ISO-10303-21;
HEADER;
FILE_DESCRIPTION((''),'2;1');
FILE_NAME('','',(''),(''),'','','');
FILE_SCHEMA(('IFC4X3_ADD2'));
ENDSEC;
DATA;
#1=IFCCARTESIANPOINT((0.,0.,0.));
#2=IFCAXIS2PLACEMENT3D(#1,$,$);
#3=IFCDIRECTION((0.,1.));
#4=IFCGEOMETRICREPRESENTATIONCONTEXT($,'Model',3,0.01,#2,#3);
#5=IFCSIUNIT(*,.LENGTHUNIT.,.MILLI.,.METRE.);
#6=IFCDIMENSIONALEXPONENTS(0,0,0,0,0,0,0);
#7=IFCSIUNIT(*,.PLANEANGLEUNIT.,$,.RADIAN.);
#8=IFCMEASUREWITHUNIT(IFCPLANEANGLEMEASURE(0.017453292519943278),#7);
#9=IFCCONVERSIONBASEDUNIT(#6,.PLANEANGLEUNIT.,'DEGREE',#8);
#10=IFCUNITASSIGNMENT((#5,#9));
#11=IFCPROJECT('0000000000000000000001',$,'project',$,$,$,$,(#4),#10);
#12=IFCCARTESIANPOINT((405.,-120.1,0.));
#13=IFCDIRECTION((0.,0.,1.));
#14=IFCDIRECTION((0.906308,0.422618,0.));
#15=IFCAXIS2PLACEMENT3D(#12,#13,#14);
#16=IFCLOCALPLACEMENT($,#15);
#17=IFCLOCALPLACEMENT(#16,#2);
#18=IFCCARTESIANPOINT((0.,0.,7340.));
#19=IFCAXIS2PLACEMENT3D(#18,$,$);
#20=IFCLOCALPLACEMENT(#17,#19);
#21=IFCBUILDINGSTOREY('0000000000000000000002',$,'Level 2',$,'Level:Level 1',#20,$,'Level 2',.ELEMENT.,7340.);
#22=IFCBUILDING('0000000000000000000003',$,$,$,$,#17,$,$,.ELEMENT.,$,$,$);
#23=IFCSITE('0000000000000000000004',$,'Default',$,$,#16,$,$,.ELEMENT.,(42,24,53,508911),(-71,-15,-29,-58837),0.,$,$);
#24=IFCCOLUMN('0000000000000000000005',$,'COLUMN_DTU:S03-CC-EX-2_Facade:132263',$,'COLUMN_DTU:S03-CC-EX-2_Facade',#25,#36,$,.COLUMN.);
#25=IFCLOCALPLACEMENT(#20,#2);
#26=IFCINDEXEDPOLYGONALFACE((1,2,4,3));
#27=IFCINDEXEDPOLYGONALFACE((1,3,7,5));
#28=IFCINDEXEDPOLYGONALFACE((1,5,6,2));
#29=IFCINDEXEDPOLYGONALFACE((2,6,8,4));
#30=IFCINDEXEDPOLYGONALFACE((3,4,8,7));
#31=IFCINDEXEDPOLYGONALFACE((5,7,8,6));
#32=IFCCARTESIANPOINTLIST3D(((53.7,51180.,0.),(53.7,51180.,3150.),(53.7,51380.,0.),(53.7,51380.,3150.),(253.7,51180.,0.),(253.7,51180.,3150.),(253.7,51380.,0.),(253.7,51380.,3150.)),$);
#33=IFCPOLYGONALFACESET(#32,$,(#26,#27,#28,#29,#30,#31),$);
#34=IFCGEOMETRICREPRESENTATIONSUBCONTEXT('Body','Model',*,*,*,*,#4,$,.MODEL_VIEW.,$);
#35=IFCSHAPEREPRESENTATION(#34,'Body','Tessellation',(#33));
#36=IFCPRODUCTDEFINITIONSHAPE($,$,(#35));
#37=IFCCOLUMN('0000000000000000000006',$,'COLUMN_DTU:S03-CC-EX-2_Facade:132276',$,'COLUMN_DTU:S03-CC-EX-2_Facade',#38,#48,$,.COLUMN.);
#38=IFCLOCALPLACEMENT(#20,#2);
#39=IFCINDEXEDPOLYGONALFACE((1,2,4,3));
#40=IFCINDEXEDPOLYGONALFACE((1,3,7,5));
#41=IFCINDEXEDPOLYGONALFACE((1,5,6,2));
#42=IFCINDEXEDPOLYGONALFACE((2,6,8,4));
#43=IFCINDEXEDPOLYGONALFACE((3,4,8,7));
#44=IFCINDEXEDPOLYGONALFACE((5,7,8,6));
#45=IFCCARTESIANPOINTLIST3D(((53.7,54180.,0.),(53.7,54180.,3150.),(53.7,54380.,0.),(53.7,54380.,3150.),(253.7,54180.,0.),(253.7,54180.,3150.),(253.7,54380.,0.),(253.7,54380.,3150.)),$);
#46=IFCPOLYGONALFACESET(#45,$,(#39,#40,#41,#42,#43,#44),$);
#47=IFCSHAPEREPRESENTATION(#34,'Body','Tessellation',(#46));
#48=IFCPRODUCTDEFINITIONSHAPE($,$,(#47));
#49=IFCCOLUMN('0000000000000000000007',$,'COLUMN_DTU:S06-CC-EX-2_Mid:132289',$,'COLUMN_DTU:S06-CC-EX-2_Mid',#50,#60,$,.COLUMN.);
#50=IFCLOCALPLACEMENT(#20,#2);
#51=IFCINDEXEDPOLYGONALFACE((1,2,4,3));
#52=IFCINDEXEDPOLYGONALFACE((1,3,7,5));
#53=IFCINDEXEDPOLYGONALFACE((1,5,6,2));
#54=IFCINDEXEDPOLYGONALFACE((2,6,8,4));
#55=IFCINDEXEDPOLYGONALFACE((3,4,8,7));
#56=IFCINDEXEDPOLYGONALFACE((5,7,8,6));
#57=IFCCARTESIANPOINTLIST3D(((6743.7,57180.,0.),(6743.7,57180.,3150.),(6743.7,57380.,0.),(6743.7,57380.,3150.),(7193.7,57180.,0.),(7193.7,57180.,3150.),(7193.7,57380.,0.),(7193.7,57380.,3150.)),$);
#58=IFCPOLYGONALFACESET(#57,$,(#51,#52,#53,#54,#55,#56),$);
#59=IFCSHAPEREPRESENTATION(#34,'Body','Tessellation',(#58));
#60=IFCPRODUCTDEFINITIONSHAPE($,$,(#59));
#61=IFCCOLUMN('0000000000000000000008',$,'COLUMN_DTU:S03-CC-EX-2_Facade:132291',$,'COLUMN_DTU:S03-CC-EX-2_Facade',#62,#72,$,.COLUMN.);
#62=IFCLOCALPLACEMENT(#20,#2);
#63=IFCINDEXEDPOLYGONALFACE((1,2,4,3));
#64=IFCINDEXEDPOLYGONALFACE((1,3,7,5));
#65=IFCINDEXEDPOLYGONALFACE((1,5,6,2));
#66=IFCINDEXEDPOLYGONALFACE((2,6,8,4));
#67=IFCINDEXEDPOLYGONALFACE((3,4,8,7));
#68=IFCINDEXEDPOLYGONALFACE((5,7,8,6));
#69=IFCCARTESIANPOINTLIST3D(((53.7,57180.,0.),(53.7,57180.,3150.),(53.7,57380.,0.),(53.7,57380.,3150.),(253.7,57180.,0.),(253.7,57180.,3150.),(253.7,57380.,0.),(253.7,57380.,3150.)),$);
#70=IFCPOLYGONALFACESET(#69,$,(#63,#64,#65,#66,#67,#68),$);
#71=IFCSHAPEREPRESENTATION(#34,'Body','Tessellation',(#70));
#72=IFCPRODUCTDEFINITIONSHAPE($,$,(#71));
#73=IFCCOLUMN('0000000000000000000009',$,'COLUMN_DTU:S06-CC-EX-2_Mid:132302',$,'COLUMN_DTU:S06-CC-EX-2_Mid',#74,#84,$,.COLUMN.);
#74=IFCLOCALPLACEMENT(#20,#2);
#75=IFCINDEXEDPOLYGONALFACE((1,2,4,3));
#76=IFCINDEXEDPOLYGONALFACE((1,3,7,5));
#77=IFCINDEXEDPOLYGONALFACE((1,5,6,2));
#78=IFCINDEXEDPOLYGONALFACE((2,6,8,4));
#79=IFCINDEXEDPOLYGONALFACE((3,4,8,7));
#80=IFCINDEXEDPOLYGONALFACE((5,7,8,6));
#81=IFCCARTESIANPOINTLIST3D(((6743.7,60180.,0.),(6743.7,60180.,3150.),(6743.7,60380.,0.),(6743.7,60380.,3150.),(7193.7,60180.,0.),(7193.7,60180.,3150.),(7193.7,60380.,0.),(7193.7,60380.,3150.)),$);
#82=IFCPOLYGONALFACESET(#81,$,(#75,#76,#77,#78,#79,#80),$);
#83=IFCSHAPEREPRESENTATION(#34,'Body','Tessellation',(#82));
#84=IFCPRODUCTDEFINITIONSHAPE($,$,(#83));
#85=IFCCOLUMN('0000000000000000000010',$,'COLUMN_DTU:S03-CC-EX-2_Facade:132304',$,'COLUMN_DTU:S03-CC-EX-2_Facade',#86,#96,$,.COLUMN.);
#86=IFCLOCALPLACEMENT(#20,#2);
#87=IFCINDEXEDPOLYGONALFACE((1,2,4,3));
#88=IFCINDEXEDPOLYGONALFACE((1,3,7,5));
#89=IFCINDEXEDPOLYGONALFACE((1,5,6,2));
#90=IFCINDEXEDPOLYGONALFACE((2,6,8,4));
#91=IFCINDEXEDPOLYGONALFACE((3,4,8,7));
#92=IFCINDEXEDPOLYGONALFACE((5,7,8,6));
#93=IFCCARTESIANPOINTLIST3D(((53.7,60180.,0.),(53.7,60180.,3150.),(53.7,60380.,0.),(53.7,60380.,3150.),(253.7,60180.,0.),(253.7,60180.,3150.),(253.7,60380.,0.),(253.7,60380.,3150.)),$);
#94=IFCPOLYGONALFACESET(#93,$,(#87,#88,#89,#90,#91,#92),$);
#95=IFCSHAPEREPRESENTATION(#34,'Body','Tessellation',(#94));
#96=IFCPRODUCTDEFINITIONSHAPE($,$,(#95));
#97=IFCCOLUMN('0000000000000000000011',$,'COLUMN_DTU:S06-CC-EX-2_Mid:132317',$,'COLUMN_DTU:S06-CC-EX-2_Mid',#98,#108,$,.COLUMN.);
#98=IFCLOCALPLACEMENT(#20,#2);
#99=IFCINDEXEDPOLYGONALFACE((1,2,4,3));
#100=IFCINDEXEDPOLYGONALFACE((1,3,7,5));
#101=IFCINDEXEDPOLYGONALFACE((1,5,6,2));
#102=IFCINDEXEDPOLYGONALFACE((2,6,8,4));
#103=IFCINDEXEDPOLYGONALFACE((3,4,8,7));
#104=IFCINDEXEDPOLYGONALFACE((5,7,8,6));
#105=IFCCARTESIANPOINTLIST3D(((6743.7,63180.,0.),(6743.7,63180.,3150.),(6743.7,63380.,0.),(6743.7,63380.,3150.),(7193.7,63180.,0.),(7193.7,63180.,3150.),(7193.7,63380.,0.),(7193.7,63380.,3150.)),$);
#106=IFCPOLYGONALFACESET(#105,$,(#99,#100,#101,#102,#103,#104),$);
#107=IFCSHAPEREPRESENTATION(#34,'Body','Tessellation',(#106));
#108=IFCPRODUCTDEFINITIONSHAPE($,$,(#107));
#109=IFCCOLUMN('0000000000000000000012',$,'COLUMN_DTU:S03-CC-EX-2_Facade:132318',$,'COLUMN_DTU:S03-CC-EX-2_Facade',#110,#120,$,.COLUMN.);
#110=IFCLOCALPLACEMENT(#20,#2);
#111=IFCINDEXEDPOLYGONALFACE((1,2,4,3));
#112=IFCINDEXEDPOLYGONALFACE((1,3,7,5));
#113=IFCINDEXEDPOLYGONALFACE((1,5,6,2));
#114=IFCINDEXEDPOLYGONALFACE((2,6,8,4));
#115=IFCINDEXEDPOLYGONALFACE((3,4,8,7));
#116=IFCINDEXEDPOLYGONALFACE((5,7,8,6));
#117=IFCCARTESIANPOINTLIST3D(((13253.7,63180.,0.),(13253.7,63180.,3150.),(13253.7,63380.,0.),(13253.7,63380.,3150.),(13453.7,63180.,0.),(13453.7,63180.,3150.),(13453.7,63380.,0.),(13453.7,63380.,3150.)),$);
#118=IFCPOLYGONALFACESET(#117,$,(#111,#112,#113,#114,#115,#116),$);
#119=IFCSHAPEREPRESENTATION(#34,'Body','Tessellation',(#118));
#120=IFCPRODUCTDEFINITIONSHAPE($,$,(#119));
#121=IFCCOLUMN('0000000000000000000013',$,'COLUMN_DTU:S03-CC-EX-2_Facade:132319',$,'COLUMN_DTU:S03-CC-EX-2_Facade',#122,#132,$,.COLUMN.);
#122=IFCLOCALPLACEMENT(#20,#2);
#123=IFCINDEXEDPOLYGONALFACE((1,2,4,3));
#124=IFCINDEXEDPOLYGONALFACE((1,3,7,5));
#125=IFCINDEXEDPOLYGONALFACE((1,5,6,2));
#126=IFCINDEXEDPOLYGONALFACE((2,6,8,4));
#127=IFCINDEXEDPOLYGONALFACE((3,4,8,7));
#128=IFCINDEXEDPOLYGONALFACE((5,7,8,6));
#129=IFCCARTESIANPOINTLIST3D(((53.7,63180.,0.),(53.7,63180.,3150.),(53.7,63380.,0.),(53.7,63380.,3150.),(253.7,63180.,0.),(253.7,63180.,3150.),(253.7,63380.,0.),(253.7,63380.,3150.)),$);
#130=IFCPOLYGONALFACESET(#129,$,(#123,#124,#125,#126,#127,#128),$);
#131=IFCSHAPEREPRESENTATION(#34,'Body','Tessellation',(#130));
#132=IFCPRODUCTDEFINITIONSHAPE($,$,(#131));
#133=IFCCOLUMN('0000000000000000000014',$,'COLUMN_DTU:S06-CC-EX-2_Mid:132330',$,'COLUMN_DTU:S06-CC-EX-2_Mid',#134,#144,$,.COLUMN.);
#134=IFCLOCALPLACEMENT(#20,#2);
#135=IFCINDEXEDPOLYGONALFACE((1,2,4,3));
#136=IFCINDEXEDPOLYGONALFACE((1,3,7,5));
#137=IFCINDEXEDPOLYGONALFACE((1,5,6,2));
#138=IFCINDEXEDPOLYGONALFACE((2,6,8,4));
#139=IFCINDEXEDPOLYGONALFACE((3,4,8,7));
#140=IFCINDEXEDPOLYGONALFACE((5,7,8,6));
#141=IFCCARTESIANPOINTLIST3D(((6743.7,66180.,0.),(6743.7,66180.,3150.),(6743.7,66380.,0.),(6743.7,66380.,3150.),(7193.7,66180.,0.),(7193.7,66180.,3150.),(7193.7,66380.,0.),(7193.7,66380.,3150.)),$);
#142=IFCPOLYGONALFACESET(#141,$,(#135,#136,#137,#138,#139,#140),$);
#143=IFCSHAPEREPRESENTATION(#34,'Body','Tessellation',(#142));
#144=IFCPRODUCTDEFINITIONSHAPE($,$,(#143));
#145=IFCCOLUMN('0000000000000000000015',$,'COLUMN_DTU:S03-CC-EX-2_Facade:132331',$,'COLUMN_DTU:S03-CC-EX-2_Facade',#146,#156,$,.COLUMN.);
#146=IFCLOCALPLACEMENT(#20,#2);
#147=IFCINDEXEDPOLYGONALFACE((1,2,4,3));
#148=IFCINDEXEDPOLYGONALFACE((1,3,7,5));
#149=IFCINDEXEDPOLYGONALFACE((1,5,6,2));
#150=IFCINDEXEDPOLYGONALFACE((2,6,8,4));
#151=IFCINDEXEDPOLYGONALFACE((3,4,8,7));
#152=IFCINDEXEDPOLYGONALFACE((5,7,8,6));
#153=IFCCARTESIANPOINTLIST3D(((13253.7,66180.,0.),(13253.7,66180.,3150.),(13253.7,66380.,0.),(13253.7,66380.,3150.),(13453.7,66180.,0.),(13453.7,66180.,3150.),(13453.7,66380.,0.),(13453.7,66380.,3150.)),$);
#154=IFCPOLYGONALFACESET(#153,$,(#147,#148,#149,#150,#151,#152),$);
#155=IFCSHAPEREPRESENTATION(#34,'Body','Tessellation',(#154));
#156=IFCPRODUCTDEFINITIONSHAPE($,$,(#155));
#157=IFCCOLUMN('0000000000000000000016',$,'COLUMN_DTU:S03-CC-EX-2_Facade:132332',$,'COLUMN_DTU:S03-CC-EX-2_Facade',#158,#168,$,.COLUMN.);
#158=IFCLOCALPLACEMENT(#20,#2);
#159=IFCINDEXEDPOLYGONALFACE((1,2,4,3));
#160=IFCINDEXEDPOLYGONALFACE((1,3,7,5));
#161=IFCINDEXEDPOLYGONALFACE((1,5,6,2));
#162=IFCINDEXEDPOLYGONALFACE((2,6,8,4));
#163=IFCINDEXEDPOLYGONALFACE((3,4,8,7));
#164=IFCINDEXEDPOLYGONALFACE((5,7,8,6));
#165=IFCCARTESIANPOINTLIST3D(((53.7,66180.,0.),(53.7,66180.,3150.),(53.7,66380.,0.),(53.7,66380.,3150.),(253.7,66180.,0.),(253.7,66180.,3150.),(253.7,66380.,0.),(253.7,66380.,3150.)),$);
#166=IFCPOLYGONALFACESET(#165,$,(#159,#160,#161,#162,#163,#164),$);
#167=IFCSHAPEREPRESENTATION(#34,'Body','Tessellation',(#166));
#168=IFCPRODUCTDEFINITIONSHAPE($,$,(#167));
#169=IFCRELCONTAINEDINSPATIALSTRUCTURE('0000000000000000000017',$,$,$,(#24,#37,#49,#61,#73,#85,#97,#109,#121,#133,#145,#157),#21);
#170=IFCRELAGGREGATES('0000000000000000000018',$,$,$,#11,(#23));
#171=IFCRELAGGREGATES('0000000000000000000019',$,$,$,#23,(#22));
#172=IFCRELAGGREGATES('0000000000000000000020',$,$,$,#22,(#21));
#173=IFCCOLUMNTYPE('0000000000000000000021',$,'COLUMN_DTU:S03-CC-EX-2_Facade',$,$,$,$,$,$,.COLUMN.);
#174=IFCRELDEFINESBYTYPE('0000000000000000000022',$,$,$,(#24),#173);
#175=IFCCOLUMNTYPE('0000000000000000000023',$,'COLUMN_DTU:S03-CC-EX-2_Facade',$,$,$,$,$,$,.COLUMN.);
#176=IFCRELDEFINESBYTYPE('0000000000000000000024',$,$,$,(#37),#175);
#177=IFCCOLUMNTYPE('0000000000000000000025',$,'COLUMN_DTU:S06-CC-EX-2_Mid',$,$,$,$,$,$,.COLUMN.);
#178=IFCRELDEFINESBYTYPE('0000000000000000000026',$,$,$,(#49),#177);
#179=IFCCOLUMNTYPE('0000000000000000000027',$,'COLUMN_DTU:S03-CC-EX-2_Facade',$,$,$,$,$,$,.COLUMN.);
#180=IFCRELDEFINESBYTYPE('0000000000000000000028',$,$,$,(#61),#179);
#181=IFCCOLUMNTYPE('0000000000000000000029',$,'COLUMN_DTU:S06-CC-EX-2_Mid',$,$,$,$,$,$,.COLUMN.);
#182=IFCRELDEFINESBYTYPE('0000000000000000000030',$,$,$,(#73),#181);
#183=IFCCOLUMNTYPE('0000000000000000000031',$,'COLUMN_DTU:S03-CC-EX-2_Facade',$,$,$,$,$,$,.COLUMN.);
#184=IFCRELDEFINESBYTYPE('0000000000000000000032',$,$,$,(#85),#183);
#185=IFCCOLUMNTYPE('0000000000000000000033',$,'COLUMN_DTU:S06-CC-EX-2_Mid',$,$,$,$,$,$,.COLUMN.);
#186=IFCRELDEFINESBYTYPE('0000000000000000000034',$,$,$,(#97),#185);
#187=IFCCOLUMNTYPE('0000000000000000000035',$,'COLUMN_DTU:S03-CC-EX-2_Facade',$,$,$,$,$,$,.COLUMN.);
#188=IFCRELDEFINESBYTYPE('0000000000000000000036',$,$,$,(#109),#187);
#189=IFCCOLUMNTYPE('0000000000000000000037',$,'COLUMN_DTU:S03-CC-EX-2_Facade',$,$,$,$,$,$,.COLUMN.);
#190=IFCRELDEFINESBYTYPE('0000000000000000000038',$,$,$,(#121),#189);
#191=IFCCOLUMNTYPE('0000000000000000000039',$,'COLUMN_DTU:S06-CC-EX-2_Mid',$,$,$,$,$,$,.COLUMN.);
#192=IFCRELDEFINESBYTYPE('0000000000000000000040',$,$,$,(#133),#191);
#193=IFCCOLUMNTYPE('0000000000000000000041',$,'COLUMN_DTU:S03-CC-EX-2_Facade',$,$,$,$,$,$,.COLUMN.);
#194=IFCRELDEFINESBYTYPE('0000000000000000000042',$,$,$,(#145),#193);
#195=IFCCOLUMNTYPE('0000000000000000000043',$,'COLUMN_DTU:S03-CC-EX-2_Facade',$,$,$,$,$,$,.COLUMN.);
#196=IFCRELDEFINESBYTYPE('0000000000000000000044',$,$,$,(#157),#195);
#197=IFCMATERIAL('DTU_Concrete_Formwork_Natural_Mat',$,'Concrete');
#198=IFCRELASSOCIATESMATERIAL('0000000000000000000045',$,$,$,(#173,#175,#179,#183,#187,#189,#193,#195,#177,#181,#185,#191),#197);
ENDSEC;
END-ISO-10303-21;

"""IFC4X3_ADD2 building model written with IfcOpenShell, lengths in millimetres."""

from ifc_helpers import new_model, entity, si_unit, converted_unit, direction, frame, frame_2d, origin, origin_2d_with_axis, place, context, subcontext, project, spatial, rectangle, extrude, source, transform, mapped, material, material_profile, profile_set, type_object, type_shapes, element, save


model = new_model("IFC4X3_ADD2")

# Units and contexts
model_context = context("Model", 3, precision=0.01, world=origin(), true_north=direction((0.0, 1.0)))
body_context = subcontext(model_context, "Body", "Model", "MODEL_VIEW")
ifc_project = project(units=[si_unit("LENGTHUNIT", "METRE", prefix="MILLI"), converted_unit("PLANEANGLEUNIT", "DEGREE", entity("IfcPlaneAngleMeasure", 0.017453292519943278), si_unit("PLANEANGLEUNIT", "RADIAN"), dimensions=[0, 0, 0, 0, 0, 0, 0])], contexts=[model_context])

# Site, building, storey
site_placement = place(None, frame((405.0, -120.1, 0.0), z_axis=(0.0, 0.0, 1.0), x_axis=(0.906308, 0.422618, 0.0)))
site = spatial("IfcSite", under=ifc_project, at=site_placement, Name="Default", CompositionType="ELEMENT", RefLatitude=(42, 24, 53, 508911), RefLongitude=(-71, -15, -29, -58837), RefElevation=0.0)
building_placement = place(site_placement, origin())
building = spatial("IfcBuilding", under=site, at=building_placement, CompositionType="ELEMENT")
storey_placement = place(building_placement, frame((0.0, 0.0, 7340.0)))
storey = spatial("IfcBuildingStorey", under=building, at=storey_placement, Name="Level 2", ObjectType="Level:Level 1", LongName="Level 2", CompositionType="ELEMENT", Elevation=7340.0)

# Columns
ifc_material = material(Name="DTU_Concrete_Formwork_Natural_Mat", Category="Concrete")
ifc_material_profile_1 = material_profile(ifc_material, rectangle(XDim=200.0, YDim=450.0, at=origin_2d_with_axis()), Name="S06-CC-EX-2_Mid")
ifc_profile_set_1 = profile_set([ifc_material_profile_1], Name="S06-CC-EX-2_Mid")
ifc_material_profile_2 = material_profile(ifc_material, rectangle(XDim=200.0, YDim=200.0, at=frame_2d((0.0, 0.0), x_axis=(1.0, 0.0))), Name="S03-CC-EX-2_Facade")
ifc_profile_set_2 = profile_set([ifc_material_profile_2], Name="S03-CC-EX-2_Facade")
column_type_1 = type_object("IfcColumnType", Name="COLUMN_DTU:S03-CC-EX-2_Facade", PredefinedType="COLUMN", material=ifc_profile_set_2)
shared_shape_1 = source(origin(), body_context, "Body", "SweptSolid", [
    extrude(rectangle(XDim=200.0, YDim=200.0, at=frame_2d((0.0, 0.0), x_axis=(1.0, 0.0))), frame((153.7, 51280.0, 7340.0), z_axis=(0.0, 0.0, 1.0), x_axis=(0.0, -1.0, 0.0)), (0.0, 0.0, 1.0), 3150.0),
])
type_shapes(column_type_1, [shared_shape_1])
column_1_placement = place(storey_placement, frame((0.0, 0.0, -7340.0)))
element("IfcColumn", 1, at=column_1_placement, inside=storey, type_object=column_type_1, Name="COLUMN_DTU:S03-CC-EX-2_Facade:132263", ObjectType="COLUMN_DTU:S03-CC-EX-2_Facade", PredefinedType="COLUMN", context=body_context, shape_type="MappedRepresentation", body=[
    mapped(shared_shape_1, transform((0.0, 0.0, 0.0), scale=1.0)),
])
column_type_2 = type_object("IfcColumnType", Name="COLUMN_DTU:S03-CC-EX-2_Facade", PredefinedType="COLUMN", material=ifc_profile_set_2)
shared_shape_2 = source(origin(), body_context, "Body", "SweptSolid", [
    extrude(rectangle(XDim=200.0, YDim=200.0, at=frame_2d((0.0, 0.0), x_axis=(1.0, 0.0))), frame((153.7, 54280.0, 7340.0), z_axis=(0.0, 0.0, 1.0), x_axis=(0.0, -1.0, 0.0)), (0.0, 0.0, 1.0), 3150.0),
])
type_shapes(column_type_2, [shared_shape_2])
column_2_placement = place(storey_placement, frame((0.0, 0.0, -7340.0)))
element("IfcColumn", 2, at=column_2_placement, inside=storey, type_object=column_type_2, Name="COLUMN_DTU:S03-CC-EX-2_Facade:132276", ObjectType="COLUMN_DTU:S03-CC-EX-2_Facade", PredefinedType="COLUMN", context=body_context, shape_type="MappedRepresentation", body=[
    mapped(shared_shape_2, transform((0.0, 0.0, 0.0), scale=1.0)),
])
column_type_3 = type_object("IfcColumnType", Name="COLUMN_DTU:S06-CC-EX-2_Mid", PredefinedType="COLUMN", material=ifc_profile_set_1)
shared_shape_3 = source(origin(), body_context, "Body", "SweptSolid", [
    extrude(rectangle(XDim=200.0, YDim=450.0, at=frame_2d((0.0, 0.0), x_axis=(1.0, 0.0))), frame((6968.7, 57280.0, 7340.0), z_axis=(0.0, 0.0, 1.0), x_axis=(0.0, 1.0, 0.0)), (0.0, 0.0, 1.0), 3150.0),
])
type_shapes(column_type_3, [shared_shape_3])
column_3_placement = place(storey_placement, frame((0.0, 0.0, -7340.0)))
element("IfcColumn", 3, at=column_3_placement, inside=storey, type_object=column_type_3, Name="COLUMN_DTU:S06-CC-EX-2_Mid:132289", ObjectType="COLUMN_DTU:S06-CC-EX-2_Mid", PredefinedType="COLUMN", context=body_context, shape_type="MappedRepresentation", body=[
    mapped(shared_shape_3, transform((0.0, 0.0, 0.0), scale=1.0)),
])
column_type_4 = type_object("IfcColumnType", Name="COLUMN_DTU:S03-CC-EX-2_Facade", PredefinedType="COLUMN", material=ifc_profile_set_2)
shared_shape_4 = source(origin(), body_context, "Body", "SweptSolid", [
    extrude(rectangle(XDim=200.0, YDim=200.0, at=frame_2d((0.0, 0.0), x_axis=(1.0, 0.0))), frame((153.7, 57280.0, 7340.0), z_axis=(0.0, 0.0, 1.0), x_axis=(0.0, -1.0, 0.0)), (0.0, 0.0, 1.0), 3150.0),
])
type_shapes(column_type_4, [shared_shape_4])
column_4_placement = place(storey_placement, frame((0.0, 0.0, -7340.0)))
element("IfcColumn", 4, at=column_4_placement, inside=storey, type_object=column_type_4, Name="COLUMN_DTU:S03-CC-EX-2_Facade:132291", ObjectType="COLUMN_DTU:S03-CC-EX-2_Facade", PredefinedType="COLUMN", context=body_context, shape_type="MappedRepresentation", body=[
    mapped(shared_shape_4, transform((0.0, 0.0, 0.0), scale=1.0)),
])
column_type_5 = type_object("IfcColumnType", Name="COLUMN_DTU:S06-CC-EX-2_Mid", PredefinedType="COLUMN", material=ifc_profile_set_1)
shared_shape_5 = source(origin(), body_context, "Body", "SweptSolid", [
    extrude(rectangle(XDim=200.0, YDim=450.0, at=frame_2d((0.0, 0.0), x_axis=(1.0, 0.0))), frame((6968.7, 60280.0, 7340.0), z_axis=(0.0, 0.0, 1.0), x_axis=(0.0, 1.0, 0.0)), (0.0, 0.0, 1.0), 3150.0),
])
type_shapes(column_type_5, [shared_shape_5])
column_5_placement = place(storey_placement, frame((0.0, 0.0, -7340.0)))
element("IfcColumn", 5, at=column_5_placement, inside=storey, type_object=column_type_5, Name="COLUMN_DTU:S06-CC-EX-2_Mid:132302", ObjectType="COLUMN_DTU:S06-CC-EX-2_Mid", PredefinedType="COLUMN", context=body_context, shape_type="MappedRepresentation", body=[
    mapped(shared_shape_5, transform((0.0, 0.0, 0.0), scale=1.0)),
])
column_type_6 = type_object("IfcColumnType", Name="COLUMN_DTU:S03-CC-EX-2_Facade", PredefinedType="COLUMN", material=ifc_profile_set_2)
shared_shape_6 = source(origin(), body_context, "Body", "SweptSolid", [
    extrude(rectangle(XDim=200.0, YDim=200.0, at=frame_2d((0.0, 0.0), x_axis=(1.0, 0.0))), frame((153.7, 60280.0, 7340.0), z_axis=(0.0, 0.0, 1.0), x_axis=(0.0, -1.0, 0.0)), (0.0, 0.0, 1.0), 3150.0),
])
type_shapes(column_type_6, [shared_shape_6])
column_6_placement = place(storey_placement, frame((0.0, 0.0, -7340.0)))
element("IfcColumn", 6, at=column_6_placement, inside=storey, type_object=column_type_6, Name="COLUMN_DTU:S03-CC-EX-2_Facade:132304", ObjectType="COLUMN_DTU:S03-CC-EX-2_Facade", PredefinedType="COLUMN", context=body_context, shape_type="MappedRepresentation", body=[
    mapped(shared_shape_6, transform((0.0, 0.0, 0.0), scale=1.0)),
])
column_type_7 = type_object("IfcColumnType", Name="COLUMN_DTU:S06-CC-EX-2_Mid", PredefinedType="COLUMN", material=ifc_profile_set_1)
shared_shape_7 = source(origin(), body_context, "Body", "SweptSolid", [
    extrude(rectangle(XDim=200.0, YDim=450.0, at=frame_2d((0.0, 0.0), x_axis=(1.0, 0.0))), frame((6968.7, 63280.0, 7340.0), z_axis=(0.0, 0.0, 1.0), x_axis=(0.0, 1.0, 0.0)), (0.0, 0.0, 1.0), 3150.0),
])
type_shapes(column_type_7, [shared_shape_7])
column_7_placement = place(storey_placement, frame((0.0, 0.0, -7340.0)))
element("IfcColumn", 7, at=column_7_placement, inside=storey, type_object=column_type_7, Name="COLUMN_DTU:S06-CC-EX-2_Mid:132317", ObjectType="COLUMN_DTU:S06-CC-EX-2_Mid", PredefinedType="COLUMN", context=body_context, shape_type="MappedRepresentation", body=[
    mapped(shared_shape_7, transform((0.0, 0.0, 0.0), scale=1.0)),
])
column_type_8 = type_object("IfcColumnType", Name="COLUMN_DTU:S03-CC-EX-2_Facade", PredefinedType="COLUMN", material=ifc_profile_set_2)
shared_shape_8 = source(origin(), body_context, "Body", "SweptSolid", [
    extrude(rectangle(XDim=200.0, YDim=200.0, at=frame_2d((0.0, 0.0), x_axis=(1.0, 0.0))), frame((13353.7, 63280.0, 7340.0), z_axis=(0.0, 0.0, 1.0), x_axis=(0.0, -1.0, 0.0)), (0.0, 0.0, 1.0), 3150.0),
])
type_shapes(column_type_8, [shared_shape_8])
column_8_placement = place(storey_placement, frame((0.0, 0.0, -7340.0)))
element("IfcColumn", 8, at=column_8_placement, inside=storey, type_object=column_type_8, Name="COLUMN_DTU:S03-CC-EX-2_Facade:132318", ObjectType="COLUMN_DTU:S03-CC-EX-2_Facade", PredefinedType="COLUMN", context=body_context, shape_type="MappedRepresentation", body=[
    mapped(shared_shape_8, transform((0.0, 0.0, 0.0), scale=1.0)),
])
column_type_9 = type_object("IfcColumnType", Name="COLUMN_DTU:S03-CC-EX-2_Facade", PredefinedType="COLUMN", material=ifc_profile_set_2)
shared_shape_9 = source(origin(), body_context, "Body", "SweptSolid", [
    extrude(rectangle(XDim=200.0, YDim=200.0, at=frame_2d((0.0, 0.0), x_axis=(1.0, 0.0))), frame((153.7, 63280.0, 7340.0), z_axis=(0.0, 0.0, 1.0), x_axis=(0.0, -1.0, 0.0)), (0.0, 0.0, 1.0), 3150.0),
])
type_shapes(column_type_9, [shared_shape_9])
column_9_placement = place(storey_placement, frame((0.0, 0.0, -7340.0)))
element("IfcColumn", 9, at=column_9_placement, inside=storey, type_object=column_type_9, Name="COLUMN_DTU:S03-CC-EX-2_Facade:132319", ObjectType="COLUMN_DTU:S03-CC-EX-2_Facade", PredefinedType="COLUMN", context=body_context, shape_type="MappedRepresentation", body=[
    mapped(shared_shape_9, transform((0.0, 0.0, 0.0), scale=1.0)),
])
column_type_10 = type_object("IfcColumnType", Name="COLUMN_DTU:S06-CC-EX-2_Mid", PredefinedType="COLUMN", material=ifc_profile_set_1)
shared_shape_10 = source(origin(), body_context, "Body", "SweptSolid", [
    extrude(rectangle(XDim=200.0, YDim=450.0, at=frame_2d((0.0, 0.0), x_axis=(1.0, 0.0))), frame((6968.7, 66280.0, 7340.0), z_axis=(0.0, 0.0, 1.0), x_axis=(0.0, 1.0, 0.0)), (0.0, 0.0, 1.0), 3150.0),
])
type_shapes(column_type_10, [shared_shape_10])
column_10_placement = place(storey_placement, frame((0.0, 0.0, -7340.0)))
element("IfcColumn", 10, at=column_10_placement, inside=storey, type_object=column_type_10, Name="COLUMN_DTU:S06-CC-EX-2_Mid:132330", ObjectType="COLUMN_DTU:S06-CC-EX-2_Mid", PredefinedType="COLUMN", context=body_context, shape_type="MappedRepresentation", body=[
    mapped(shared_shape_10, transform((0.0, 0.0, 0.0), scale=1.0)),
])
column_type_11 = type_object("IfcColumnType", Name="COLUMN_DTU:S03-CC-EX-2_Facade", PredefinedType="COLUMN", material=ifc_profile_set_2)
shared_shape_11 = source(origin(), body_context, "Body", "SweptSolid", [
    extrude(rectangle(XDim=200.0, YDim=200.0, at=frame_2d((0.0, 0.0), x_axis=(1.0, 0.0))), frame((13353.7, 66280.0, 7340.0), z_axis=(0.0, 0.0, 1.0), x_axis=(0.0, -1.0, 0.0)), (0.0, 0.0, 1.0), 3150.0),
])
type_shapes(column_type_11, [shared_shape_11])
column_11_placement = place(storey_placement, frame((0.0, 0.0, -7340.0)))
element("IfcColumn", 11, at=column_11_placement, inside=storey, type_object=column_type_11, Name="COLUMN_DTU:S03-CC-EX-2_Facade:132331", ObjectType="COLUMN_DTU:S03-CC-EX-2_Facade", PredefinedType="COLUMN", context=body_context, shape_type="MappedRepresentation", body=[
    mapped(shared_shape_11, transform((0.0, 0.0, 0.0), scale=1.0)),
])
column_type_12 = type_object("IfcColumnType", Name="COLUMN_DTU:S03-CC-EX-2_Facade", PredefinedType="COLUMN", material=ifc_profile_set_2)
shared_shape_12 = source(origin(), body_context, "Body", "SweptSolid", [
    extrude(rectangle(XDim=200.0, YDim=200.0, at=frame_2d((0.0, 0.0), x_axis=(1.0, 0.0))), frame((153.7, 66280.0, 7340.0), z_axis=(0.0, 0.0, 1.0), x_axis=(0.0, -1.0, 0.0)), (0.0, 0.0, 1.0), 3150.0),
])
type_shapes(column_type_12, [shared_shape_12])
column_12_placement = place(storey_placement, frame((0.0, 0.0, -7340.0)))
element("IfcColumn", 12, at=column_12_placement, inside=storey, type_object=column_type_12, Name="COLUMN_DTU:S03-CC-EX-2_Facade:132332", ObjectType="COLUMN_DTU:S03-CC-EX-2_Facade", PredefinedType="COLUMN", context=body_context, shape_type="MappedRepresentation", body=[
    mapped(shared_shape_12, transform((0.0, 0.0, 0.0), scale=1.0)),
])

save(model, "model.ifc")
